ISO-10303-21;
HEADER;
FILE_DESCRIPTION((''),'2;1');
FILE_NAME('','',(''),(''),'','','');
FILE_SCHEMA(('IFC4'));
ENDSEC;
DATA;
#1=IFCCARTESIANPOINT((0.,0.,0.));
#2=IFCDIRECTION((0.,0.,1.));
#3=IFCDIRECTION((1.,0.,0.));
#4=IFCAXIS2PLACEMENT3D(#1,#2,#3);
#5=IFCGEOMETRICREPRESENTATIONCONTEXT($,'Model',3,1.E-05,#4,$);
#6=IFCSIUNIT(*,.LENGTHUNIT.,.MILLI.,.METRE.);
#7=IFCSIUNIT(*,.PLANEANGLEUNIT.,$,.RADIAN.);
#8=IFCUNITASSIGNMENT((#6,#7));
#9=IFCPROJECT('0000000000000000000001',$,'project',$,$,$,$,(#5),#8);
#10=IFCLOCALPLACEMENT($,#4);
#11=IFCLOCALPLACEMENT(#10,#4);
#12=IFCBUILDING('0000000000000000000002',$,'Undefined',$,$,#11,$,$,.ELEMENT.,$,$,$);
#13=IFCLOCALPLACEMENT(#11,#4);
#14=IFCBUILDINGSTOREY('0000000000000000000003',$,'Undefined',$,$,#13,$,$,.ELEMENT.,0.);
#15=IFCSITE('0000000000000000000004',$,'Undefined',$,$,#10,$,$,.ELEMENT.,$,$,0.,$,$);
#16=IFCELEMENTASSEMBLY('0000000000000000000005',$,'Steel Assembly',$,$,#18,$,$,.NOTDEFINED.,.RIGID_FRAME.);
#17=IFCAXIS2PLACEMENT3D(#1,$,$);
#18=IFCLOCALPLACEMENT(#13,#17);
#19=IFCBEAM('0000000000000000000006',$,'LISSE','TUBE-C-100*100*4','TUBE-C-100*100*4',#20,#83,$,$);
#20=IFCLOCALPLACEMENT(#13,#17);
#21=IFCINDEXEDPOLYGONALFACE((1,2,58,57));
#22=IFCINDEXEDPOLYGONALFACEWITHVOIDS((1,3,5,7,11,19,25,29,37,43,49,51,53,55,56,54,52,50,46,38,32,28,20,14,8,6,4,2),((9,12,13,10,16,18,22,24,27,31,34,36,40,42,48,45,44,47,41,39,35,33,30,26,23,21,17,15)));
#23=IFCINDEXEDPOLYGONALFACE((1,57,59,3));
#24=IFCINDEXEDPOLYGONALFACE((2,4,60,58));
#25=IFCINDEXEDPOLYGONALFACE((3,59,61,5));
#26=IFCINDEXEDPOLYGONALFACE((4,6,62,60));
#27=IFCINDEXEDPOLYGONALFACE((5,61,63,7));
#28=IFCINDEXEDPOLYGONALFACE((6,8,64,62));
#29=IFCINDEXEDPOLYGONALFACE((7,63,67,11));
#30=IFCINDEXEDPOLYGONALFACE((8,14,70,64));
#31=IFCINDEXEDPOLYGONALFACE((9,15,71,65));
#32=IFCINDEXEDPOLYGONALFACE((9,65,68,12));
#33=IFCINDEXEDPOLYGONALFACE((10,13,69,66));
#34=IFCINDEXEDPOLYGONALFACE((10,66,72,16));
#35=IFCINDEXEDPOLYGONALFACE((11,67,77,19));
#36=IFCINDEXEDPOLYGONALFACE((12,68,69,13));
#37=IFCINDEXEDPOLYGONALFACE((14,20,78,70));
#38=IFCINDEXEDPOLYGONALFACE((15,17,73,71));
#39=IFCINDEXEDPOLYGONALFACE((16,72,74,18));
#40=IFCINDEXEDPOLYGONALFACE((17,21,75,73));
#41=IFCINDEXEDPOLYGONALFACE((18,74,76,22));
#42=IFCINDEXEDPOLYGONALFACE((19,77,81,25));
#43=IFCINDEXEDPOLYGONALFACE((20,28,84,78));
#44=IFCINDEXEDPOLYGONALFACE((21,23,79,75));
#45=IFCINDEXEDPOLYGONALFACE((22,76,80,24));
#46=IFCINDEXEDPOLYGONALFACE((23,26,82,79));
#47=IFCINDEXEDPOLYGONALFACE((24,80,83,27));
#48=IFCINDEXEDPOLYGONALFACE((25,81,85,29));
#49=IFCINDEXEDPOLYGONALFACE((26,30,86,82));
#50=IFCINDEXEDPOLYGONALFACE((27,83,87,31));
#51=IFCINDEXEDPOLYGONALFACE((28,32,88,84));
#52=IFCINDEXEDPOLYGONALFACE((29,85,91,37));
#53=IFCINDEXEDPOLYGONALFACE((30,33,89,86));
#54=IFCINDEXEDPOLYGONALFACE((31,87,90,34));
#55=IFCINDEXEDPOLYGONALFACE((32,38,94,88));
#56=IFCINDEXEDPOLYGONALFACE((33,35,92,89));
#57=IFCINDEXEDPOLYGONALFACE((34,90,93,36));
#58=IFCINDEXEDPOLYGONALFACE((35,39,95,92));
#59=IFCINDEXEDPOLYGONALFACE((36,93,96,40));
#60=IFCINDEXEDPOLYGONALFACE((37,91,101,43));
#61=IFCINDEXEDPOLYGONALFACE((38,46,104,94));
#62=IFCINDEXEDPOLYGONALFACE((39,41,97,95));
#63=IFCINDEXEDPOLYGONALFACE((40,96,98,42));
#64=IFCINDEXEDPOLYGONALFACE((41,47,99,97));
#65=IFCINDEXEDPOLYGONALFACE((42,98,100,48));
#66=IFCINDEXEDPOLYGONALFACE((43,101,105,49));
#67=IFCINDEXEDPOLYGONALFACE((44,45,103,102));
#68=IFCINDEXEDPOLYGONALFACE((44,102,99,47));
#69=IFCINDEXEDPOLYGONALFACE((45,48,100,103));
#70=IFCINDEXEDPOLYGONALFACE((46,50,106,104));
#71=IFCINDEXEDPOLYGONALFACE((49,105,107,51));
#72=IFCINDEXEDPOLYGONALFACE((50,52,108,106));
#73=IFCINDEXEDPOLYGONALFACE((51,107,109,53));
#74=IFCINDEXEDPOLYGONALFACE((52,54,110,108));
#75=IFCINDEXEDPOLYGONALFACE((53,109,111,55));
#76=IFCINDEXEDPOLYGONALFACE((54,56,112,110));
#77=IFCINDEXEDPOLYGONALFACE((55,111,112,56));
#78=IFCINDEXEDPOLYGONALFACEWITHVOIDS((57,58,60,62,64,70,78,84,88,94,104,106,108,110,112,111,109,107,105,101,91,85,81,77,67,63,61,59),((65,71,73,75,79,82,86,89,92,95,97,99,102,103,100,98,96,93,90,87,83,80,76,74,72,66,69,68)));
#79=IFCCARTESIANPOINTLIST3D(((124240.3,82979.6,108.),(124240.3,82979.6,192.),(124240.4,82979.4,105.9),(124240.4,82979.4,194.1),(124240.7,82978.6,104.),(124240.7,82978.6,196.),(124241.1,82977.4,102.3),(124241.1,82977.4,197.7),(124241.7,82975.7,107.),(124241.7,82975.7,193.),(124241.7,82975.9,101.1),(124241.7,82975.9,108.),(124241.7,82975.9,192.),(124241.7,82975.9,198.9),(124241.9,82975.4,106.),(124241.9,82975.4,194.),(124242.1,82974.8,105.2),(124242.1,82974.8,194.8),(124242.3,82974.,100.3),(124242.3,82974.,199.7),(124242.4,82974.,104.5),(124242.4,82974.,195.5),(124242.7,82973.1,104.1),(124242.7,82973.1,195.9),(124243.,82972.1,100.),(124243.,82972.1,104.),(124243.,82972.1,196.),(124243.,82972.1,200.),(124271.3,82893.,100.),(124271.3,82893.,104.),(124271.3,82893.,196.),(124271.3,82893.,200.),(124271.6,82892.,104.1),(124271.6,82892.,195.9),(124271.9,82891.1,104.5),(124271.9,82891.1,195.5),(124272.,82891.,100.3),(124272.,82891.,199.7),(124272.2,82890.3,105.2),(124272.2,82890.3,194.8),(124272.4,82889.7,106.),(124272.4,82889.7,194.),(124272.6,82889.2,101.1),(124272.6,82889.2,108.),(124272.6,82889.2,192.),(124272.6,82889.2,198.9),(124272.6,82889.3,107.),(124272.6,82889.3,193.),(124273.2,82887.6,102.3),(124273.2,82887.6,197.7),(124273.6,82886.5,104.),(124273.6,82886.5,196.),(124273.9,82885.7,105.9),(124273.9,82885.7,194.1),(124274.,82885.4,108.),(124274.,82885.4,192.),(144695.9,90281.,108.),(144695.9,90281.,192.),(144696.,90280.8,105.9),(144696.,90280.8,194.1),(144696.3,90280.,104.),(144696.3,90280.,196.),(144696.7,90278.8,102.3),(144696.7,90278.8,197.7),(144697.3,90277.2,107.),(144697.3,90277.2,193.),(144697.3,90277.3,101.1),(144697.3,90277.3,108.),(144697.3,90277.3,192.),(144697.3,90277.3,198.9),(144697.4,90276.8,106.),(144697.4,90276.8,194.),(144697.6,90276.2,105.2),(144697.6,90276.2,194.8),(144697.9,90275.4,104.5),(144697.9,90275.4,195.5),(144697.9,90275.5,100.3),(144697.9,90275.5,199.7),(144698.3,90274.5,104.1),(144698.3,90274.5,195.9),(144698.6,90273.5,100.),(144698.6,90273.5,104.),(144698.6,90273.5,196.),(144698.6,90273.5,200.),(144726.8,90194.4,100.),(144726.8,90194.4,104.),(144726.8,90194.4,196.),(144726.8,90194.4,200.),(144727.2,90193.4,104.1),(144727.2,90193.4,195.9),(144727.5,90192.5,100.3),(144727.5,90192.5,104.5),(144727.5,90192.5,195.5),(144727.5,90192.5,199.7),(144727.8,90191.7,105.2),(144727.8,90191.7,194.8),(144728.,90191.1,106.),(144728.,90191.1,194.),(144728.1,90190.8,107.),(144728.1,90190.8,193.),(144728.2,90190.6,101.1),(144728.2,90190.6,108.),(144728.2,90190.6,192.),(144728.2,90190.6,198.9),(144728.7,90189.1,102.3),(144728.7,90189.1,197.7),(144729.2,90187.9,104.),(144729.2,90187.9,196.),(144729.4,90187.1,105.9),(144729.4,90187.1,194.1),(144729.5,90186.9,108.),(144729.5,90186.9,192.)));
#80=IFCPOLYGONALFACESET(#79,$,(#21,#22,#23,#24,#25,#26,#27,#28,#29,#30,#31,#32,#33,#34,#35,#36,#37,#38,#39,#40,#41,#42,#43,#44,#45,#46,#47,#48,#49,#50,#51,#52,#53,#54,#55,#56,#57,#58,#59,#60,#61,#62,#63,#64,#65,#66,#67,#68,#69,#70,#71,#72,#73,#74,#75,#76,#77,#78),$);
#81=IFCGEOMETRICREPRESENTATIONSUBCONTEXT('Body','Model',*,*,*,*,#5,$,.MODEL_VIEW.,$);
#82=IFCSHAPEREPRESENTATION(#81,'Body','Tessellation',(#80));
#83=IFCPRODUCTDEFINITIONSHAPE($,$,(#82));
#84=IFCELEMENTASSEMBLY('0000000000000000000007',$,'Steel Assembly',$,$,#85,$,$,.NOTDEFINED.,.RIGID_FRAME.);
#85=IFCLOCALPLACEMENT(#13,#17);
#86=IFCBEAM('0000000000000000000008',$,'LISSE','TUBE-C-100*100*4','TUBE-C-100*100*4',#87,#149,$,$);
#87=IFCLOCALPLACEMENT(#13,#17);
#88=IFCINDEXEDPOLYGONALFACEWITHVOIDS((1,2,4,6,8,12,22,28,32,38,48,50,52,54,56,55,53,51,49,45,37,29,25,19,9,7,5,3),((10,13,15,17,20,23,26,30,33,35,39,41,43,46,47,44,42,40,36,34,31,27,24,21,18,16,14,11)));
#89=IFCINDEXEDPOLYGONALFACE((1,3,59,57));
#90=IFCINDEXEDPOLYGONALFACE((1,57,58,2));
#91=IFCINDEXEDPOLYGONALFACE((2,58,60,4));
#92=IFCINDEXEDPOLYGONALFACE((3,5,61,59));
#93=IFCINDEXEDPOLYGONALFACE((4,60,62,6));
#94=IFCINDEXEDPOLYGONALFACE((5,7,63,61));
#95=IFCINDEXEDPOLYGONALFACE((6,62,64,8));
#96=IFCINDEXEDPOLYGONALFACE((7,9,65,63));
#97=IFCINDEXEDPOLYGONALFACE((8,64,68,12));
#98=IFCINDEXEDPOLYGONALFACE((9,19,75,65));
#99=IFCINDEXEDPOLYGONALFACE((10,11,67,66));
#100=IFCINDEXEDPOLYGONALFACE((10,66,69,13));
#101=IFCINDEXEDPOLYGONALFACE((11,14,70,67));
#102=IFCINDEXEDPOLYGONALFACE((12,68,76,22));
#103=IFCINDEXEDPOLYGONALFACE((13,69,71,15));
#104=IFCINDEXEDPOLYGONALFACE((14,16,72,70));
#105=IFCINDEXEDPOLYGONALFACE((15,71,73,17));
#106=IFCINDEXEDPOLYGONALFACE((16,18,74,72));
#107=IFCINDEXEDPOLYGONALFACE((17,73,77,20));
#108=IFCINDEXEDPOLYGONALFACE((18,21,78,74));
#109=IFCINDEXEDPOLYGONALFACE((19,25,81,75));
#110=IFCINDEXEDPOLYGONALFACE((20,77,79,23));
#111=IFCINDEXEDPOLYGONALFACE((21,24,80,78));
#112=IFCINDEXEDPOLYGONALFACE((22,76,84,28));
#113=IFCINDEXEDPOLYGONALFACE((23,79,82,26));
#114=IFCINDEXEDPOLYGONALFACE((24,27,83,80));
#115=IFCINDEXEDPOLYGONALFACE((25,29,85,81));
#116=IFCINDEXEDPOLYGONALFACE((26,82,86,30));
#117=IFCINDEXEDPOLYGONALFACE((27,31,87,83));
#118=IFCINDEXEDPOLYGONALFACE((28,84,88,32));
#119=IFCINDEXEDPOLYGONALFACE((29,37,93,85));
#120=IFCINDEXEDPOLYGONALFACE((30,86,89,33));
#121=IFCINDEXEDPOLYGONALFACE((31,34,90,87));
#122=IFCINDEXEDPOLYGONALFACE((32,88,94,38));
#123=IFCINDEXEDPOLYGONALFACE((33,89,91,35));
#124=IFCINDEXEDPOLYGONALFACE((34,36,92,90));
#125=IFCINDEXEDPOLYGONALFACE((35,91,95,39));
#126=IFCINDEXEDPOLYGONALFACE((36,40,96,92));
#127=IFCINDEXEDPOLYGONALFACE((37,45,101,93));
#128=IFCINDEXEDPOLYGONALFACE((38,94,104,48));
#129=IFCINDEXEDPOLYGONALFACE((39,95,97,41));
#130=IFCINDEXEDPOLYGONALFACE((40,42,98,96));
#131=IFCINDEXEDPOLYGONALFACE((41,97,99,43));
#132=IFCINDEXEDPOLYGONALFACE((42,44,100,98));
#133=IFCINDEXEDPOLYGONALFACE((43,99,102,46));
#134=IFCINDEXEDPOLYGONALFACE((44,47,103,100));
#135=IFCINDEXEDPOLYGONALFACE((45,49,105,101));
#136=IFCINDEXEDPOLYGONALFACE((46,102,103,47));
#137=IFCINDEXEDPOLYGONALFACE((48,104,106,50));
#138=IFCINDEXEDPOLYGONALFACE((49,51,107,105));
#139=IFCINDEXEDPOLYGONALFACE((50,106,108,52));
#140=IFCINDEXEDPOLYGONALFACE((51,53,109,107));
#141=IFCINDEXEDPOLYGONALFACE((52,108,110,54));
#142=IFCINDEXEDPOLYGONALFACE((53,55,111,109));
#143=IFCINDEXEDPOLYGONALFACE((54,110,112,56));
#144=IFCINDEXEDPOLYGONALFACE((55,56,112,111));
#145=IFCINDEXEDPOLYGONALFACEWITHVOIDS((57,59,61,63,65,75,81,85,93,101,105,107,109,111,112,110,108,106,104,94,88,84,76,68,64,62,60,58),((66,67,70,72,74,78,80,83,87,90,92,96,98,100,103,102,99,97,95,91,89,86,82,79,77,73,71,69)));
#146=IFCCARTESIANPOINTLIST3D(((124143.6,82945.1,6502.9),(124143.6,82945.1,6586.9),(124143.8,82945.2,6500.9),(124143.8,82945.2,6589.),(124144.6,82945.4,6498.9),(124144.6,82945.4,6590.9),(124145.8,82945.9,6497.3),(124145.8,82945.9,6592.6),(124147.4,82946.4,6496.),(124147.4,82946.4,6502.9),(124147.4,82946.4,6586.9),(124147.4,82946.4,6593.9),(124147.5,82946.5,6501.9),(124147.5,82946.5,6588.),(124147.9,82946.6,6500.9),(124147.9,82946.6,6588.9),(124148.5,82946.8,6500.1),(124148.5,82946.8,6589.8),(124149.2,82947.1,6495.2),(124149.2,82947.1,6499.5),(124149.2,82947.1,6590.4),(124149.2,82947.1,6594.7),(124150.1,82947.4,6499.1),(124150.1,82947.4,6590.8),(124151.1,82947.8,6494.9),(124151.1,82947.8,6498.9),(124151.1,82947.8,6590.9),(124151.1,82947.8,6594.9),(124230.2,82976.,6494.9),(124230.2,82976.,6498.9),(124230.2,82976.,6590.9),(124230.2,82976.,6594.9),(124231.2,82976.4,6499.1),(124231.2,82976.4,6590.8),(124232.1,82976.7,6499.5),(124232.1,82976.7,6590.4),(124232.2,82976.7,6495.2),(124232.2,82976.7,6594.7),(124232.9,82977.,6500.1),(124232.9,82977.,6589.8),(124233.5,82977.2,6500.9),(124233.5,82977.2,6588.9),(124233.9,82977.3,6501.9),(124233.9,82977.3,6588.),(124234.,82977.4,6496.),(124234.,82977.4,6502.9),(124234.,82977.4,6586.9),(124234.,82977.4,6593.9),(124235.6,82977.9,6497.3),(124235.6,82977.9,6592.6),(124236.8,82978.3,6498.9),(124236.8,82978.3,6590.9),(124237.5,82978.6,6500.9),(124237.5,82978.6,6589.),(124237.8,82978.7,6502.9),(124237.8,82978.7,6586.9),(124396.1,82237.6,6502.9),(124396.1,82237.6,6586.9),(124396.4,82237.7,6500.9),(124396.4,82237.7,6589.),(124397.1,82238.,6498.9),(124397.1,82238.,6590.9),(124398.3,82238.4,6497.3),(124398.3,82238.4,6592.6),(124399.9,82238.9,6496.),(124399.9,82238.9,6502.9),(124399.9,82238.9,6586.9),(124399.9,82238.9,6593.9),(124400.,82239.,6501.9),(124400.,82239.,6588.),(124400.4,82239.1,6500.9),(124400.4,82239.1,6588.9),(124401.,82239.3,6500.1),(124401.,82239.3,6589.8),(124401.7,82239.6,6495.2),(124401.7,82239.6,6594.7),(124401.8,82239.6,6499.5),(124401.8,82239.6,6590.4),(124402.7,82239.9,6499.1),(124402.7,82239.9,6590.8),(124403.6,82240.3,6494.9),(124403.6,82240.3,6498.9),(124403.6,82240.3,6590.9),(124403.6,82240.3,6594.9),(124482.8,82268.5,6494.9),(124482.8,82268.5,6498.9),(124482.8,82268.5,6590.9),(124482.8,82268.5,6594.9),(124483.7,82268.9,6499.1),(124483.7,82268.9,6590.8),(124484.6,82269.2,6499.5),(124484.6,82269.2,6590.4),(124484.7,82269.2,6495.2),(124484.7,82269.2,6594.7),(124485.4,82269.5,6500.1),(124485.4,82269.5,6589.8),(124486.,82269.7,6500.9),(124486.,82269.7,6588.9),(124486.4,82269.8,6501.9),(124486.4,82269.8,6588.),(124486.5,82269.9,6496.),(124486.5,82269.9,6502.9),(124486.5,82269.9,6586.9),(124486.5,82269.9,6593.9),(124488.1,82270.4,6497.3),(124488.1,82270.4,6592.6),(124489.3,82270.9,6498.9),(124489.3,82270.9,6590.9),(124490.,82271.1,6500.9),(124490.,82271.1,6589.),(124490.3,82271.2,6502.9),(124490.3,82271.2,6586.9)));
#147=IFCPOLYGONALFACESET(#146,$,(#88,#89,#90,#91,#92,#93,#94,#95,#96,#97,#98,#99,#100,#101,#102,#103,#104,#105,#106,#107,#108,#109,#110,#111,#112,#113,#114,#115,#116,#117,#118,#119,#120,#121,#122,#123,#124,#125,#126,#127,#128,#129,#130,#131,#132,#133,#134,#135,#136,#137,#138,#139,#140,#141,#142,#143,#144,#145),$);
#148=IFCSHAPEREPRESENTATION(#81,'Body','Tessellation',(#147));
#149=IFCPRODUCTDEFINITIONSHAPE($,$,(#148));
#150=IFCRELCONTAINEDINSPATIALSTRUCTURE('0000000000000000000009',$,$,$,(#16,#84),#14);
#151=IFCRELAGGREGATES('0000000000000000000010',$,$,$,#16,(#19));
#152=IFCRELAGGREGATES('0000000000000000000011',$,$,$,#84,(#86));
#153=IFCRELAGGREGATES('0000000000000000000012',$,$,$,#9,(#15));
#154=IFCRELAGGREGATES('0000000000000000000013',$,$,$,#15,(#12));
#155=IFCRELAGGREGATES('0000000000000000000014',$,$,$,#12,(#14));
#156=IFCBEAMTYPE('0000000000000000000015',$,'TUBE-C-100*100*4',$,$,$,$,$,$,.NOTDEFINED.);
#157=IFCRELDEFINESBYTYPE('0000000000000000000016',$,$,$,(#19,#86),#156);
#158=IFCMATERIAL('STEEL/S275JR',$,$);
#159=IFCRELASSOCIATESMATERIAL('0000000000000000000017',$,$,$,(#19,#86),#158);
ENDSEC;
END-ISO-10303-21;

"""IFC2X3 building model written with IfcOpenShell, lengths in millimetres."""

from ifc_helpers import new_model, si_unit, frame, origin_with_axes, origin_2d_with_axis, place, context, subcontext, project, spatial, hollow_rectangle, extrude, material, type_object, element, aggregate, save


model = new_model("IFC2X3")

# Units and contexts
model_context = context("Model", 3, precision=1e-05, world=origin_with_axes())
body_context = subcontext(model_context, "Body", "Model", "MODEL_VIEW")
ifc_project = project(units=[si_unit("LENGTHUNIT", "METRE", prefix="MILLI"), si_unit("PLANEANGLEUNIT", "RADIAN")], contexts=[model_context])

# Site, building, storey
site_placement = place(None, origin_with_axes())
site = spatial("IfcSite", under=ifc_project, at=site_placement, Name="Undefined", CompositionType="ELEMENT", RefElevation=0.0)
building_placement = place(site_placement, origin_with_axes())
building = spatial("IfcBuilding", under=site, at=building_placement, Name="Undefined", CompositionType="ELEMENT")
storey_placement = place(building_placement, origin_with_axes())
storey = spatial("IfcBuildingStorey", under=building, at=storey_placement, Name="Undefined", CompositionType="ELEMENT", Elevation=0.0)

# Shared definitions
ifc_material = material(Name="STEEL/S275JR")

# Element assemblies, beams
beam_type_1 = type_object("IfcBeamType", Name="TUBE-C-100*100*4", PredefinedType="NOTDEFINED")
assembly_1_placement = place(storey_placement, origin_with_axes())
assembly_1 = element("IfcElementAssembly", 1, at=assembly_1_placement, inside=storey, Name="Steel Assembly", AssemblyPlace="NOTDEFINED", PredefinedType="RIGID_FRAME")
beam_1_placement = place(assembly_1_placement, frame((124257.1, 82932.5, 150.0), z_axis=(0.0, 0.0, -1.0), x_axis=(0.941802, 0.336168, 0.0)))
beam_1 = element("IfcBeam", 2, at=beam_1_placement, type_object=beam_type_1, material=ifc_material, Name="LISSE", Description="TUBE-C-100*100*4", ObjectType="TUBE-C-100*100*4", context=body_context, shape_type="SweptSolid", body=[
    extrude(hollow_rectangle(XDim=100.0, YDim=100.0, WallThickness=4.0, InnerFilletRadius=4.0, OuterFilletRadius=8.0, at=origin_2d_with_axis()), frame((21719.6, 0.0, 0.0), z_axis=(-1.0, 0.0, 0.0), x_axis=(0.0, -1.0, 0.0)), (0.0, 0.0, 1.0), 21719.6),
])
aggregate(assembly_1, [beam_1])
assembly_2_placement = place(storey_placement, origin_with_axes())
assembly_2 = element("IfcElementAssembly", 3, at=assembly_2_placement, inside=storey, Name="Steel Assembly", AssemblyPlace="NOTDEFINED", PredefinedType="RIGID_FRAME")
beam_2_placement = place(assembly_2_placement, frame((124443.2, 82254.4, 6544.9), z_axis=(0.941802, 0.336168, 0.0), x_axis=(-0.336168, 0.941802, 0.0)))
beam_2 = element("IfcBeam", 4, at=beam_2_placement, type_object=beam_type_1, material=ifc_material, Name="LISSE", Description="TUBE-C-100*100*4", ObjectType="TUBE-C-100*100*4", context=body_context, shape_type="SweptSolid", body=[
    extrude(hollow_rectangle(XDim=100.0, YDim=100.0, WallThickness=4.0, InnerFilletRadius=4.0, OuterFilletRadius=8.0, at=origin_2d_with_axis()), frame((751.2, 0.0, 0.0), z_axis=(-1.0, 0.0, 0.0), x_axis=(0.0, -1.0, 0.0)), (0.0, 0.0, 1.0), 751.2),
])
aggregate(assembly_2, [beam_2])

save(model, "model.ifc")
